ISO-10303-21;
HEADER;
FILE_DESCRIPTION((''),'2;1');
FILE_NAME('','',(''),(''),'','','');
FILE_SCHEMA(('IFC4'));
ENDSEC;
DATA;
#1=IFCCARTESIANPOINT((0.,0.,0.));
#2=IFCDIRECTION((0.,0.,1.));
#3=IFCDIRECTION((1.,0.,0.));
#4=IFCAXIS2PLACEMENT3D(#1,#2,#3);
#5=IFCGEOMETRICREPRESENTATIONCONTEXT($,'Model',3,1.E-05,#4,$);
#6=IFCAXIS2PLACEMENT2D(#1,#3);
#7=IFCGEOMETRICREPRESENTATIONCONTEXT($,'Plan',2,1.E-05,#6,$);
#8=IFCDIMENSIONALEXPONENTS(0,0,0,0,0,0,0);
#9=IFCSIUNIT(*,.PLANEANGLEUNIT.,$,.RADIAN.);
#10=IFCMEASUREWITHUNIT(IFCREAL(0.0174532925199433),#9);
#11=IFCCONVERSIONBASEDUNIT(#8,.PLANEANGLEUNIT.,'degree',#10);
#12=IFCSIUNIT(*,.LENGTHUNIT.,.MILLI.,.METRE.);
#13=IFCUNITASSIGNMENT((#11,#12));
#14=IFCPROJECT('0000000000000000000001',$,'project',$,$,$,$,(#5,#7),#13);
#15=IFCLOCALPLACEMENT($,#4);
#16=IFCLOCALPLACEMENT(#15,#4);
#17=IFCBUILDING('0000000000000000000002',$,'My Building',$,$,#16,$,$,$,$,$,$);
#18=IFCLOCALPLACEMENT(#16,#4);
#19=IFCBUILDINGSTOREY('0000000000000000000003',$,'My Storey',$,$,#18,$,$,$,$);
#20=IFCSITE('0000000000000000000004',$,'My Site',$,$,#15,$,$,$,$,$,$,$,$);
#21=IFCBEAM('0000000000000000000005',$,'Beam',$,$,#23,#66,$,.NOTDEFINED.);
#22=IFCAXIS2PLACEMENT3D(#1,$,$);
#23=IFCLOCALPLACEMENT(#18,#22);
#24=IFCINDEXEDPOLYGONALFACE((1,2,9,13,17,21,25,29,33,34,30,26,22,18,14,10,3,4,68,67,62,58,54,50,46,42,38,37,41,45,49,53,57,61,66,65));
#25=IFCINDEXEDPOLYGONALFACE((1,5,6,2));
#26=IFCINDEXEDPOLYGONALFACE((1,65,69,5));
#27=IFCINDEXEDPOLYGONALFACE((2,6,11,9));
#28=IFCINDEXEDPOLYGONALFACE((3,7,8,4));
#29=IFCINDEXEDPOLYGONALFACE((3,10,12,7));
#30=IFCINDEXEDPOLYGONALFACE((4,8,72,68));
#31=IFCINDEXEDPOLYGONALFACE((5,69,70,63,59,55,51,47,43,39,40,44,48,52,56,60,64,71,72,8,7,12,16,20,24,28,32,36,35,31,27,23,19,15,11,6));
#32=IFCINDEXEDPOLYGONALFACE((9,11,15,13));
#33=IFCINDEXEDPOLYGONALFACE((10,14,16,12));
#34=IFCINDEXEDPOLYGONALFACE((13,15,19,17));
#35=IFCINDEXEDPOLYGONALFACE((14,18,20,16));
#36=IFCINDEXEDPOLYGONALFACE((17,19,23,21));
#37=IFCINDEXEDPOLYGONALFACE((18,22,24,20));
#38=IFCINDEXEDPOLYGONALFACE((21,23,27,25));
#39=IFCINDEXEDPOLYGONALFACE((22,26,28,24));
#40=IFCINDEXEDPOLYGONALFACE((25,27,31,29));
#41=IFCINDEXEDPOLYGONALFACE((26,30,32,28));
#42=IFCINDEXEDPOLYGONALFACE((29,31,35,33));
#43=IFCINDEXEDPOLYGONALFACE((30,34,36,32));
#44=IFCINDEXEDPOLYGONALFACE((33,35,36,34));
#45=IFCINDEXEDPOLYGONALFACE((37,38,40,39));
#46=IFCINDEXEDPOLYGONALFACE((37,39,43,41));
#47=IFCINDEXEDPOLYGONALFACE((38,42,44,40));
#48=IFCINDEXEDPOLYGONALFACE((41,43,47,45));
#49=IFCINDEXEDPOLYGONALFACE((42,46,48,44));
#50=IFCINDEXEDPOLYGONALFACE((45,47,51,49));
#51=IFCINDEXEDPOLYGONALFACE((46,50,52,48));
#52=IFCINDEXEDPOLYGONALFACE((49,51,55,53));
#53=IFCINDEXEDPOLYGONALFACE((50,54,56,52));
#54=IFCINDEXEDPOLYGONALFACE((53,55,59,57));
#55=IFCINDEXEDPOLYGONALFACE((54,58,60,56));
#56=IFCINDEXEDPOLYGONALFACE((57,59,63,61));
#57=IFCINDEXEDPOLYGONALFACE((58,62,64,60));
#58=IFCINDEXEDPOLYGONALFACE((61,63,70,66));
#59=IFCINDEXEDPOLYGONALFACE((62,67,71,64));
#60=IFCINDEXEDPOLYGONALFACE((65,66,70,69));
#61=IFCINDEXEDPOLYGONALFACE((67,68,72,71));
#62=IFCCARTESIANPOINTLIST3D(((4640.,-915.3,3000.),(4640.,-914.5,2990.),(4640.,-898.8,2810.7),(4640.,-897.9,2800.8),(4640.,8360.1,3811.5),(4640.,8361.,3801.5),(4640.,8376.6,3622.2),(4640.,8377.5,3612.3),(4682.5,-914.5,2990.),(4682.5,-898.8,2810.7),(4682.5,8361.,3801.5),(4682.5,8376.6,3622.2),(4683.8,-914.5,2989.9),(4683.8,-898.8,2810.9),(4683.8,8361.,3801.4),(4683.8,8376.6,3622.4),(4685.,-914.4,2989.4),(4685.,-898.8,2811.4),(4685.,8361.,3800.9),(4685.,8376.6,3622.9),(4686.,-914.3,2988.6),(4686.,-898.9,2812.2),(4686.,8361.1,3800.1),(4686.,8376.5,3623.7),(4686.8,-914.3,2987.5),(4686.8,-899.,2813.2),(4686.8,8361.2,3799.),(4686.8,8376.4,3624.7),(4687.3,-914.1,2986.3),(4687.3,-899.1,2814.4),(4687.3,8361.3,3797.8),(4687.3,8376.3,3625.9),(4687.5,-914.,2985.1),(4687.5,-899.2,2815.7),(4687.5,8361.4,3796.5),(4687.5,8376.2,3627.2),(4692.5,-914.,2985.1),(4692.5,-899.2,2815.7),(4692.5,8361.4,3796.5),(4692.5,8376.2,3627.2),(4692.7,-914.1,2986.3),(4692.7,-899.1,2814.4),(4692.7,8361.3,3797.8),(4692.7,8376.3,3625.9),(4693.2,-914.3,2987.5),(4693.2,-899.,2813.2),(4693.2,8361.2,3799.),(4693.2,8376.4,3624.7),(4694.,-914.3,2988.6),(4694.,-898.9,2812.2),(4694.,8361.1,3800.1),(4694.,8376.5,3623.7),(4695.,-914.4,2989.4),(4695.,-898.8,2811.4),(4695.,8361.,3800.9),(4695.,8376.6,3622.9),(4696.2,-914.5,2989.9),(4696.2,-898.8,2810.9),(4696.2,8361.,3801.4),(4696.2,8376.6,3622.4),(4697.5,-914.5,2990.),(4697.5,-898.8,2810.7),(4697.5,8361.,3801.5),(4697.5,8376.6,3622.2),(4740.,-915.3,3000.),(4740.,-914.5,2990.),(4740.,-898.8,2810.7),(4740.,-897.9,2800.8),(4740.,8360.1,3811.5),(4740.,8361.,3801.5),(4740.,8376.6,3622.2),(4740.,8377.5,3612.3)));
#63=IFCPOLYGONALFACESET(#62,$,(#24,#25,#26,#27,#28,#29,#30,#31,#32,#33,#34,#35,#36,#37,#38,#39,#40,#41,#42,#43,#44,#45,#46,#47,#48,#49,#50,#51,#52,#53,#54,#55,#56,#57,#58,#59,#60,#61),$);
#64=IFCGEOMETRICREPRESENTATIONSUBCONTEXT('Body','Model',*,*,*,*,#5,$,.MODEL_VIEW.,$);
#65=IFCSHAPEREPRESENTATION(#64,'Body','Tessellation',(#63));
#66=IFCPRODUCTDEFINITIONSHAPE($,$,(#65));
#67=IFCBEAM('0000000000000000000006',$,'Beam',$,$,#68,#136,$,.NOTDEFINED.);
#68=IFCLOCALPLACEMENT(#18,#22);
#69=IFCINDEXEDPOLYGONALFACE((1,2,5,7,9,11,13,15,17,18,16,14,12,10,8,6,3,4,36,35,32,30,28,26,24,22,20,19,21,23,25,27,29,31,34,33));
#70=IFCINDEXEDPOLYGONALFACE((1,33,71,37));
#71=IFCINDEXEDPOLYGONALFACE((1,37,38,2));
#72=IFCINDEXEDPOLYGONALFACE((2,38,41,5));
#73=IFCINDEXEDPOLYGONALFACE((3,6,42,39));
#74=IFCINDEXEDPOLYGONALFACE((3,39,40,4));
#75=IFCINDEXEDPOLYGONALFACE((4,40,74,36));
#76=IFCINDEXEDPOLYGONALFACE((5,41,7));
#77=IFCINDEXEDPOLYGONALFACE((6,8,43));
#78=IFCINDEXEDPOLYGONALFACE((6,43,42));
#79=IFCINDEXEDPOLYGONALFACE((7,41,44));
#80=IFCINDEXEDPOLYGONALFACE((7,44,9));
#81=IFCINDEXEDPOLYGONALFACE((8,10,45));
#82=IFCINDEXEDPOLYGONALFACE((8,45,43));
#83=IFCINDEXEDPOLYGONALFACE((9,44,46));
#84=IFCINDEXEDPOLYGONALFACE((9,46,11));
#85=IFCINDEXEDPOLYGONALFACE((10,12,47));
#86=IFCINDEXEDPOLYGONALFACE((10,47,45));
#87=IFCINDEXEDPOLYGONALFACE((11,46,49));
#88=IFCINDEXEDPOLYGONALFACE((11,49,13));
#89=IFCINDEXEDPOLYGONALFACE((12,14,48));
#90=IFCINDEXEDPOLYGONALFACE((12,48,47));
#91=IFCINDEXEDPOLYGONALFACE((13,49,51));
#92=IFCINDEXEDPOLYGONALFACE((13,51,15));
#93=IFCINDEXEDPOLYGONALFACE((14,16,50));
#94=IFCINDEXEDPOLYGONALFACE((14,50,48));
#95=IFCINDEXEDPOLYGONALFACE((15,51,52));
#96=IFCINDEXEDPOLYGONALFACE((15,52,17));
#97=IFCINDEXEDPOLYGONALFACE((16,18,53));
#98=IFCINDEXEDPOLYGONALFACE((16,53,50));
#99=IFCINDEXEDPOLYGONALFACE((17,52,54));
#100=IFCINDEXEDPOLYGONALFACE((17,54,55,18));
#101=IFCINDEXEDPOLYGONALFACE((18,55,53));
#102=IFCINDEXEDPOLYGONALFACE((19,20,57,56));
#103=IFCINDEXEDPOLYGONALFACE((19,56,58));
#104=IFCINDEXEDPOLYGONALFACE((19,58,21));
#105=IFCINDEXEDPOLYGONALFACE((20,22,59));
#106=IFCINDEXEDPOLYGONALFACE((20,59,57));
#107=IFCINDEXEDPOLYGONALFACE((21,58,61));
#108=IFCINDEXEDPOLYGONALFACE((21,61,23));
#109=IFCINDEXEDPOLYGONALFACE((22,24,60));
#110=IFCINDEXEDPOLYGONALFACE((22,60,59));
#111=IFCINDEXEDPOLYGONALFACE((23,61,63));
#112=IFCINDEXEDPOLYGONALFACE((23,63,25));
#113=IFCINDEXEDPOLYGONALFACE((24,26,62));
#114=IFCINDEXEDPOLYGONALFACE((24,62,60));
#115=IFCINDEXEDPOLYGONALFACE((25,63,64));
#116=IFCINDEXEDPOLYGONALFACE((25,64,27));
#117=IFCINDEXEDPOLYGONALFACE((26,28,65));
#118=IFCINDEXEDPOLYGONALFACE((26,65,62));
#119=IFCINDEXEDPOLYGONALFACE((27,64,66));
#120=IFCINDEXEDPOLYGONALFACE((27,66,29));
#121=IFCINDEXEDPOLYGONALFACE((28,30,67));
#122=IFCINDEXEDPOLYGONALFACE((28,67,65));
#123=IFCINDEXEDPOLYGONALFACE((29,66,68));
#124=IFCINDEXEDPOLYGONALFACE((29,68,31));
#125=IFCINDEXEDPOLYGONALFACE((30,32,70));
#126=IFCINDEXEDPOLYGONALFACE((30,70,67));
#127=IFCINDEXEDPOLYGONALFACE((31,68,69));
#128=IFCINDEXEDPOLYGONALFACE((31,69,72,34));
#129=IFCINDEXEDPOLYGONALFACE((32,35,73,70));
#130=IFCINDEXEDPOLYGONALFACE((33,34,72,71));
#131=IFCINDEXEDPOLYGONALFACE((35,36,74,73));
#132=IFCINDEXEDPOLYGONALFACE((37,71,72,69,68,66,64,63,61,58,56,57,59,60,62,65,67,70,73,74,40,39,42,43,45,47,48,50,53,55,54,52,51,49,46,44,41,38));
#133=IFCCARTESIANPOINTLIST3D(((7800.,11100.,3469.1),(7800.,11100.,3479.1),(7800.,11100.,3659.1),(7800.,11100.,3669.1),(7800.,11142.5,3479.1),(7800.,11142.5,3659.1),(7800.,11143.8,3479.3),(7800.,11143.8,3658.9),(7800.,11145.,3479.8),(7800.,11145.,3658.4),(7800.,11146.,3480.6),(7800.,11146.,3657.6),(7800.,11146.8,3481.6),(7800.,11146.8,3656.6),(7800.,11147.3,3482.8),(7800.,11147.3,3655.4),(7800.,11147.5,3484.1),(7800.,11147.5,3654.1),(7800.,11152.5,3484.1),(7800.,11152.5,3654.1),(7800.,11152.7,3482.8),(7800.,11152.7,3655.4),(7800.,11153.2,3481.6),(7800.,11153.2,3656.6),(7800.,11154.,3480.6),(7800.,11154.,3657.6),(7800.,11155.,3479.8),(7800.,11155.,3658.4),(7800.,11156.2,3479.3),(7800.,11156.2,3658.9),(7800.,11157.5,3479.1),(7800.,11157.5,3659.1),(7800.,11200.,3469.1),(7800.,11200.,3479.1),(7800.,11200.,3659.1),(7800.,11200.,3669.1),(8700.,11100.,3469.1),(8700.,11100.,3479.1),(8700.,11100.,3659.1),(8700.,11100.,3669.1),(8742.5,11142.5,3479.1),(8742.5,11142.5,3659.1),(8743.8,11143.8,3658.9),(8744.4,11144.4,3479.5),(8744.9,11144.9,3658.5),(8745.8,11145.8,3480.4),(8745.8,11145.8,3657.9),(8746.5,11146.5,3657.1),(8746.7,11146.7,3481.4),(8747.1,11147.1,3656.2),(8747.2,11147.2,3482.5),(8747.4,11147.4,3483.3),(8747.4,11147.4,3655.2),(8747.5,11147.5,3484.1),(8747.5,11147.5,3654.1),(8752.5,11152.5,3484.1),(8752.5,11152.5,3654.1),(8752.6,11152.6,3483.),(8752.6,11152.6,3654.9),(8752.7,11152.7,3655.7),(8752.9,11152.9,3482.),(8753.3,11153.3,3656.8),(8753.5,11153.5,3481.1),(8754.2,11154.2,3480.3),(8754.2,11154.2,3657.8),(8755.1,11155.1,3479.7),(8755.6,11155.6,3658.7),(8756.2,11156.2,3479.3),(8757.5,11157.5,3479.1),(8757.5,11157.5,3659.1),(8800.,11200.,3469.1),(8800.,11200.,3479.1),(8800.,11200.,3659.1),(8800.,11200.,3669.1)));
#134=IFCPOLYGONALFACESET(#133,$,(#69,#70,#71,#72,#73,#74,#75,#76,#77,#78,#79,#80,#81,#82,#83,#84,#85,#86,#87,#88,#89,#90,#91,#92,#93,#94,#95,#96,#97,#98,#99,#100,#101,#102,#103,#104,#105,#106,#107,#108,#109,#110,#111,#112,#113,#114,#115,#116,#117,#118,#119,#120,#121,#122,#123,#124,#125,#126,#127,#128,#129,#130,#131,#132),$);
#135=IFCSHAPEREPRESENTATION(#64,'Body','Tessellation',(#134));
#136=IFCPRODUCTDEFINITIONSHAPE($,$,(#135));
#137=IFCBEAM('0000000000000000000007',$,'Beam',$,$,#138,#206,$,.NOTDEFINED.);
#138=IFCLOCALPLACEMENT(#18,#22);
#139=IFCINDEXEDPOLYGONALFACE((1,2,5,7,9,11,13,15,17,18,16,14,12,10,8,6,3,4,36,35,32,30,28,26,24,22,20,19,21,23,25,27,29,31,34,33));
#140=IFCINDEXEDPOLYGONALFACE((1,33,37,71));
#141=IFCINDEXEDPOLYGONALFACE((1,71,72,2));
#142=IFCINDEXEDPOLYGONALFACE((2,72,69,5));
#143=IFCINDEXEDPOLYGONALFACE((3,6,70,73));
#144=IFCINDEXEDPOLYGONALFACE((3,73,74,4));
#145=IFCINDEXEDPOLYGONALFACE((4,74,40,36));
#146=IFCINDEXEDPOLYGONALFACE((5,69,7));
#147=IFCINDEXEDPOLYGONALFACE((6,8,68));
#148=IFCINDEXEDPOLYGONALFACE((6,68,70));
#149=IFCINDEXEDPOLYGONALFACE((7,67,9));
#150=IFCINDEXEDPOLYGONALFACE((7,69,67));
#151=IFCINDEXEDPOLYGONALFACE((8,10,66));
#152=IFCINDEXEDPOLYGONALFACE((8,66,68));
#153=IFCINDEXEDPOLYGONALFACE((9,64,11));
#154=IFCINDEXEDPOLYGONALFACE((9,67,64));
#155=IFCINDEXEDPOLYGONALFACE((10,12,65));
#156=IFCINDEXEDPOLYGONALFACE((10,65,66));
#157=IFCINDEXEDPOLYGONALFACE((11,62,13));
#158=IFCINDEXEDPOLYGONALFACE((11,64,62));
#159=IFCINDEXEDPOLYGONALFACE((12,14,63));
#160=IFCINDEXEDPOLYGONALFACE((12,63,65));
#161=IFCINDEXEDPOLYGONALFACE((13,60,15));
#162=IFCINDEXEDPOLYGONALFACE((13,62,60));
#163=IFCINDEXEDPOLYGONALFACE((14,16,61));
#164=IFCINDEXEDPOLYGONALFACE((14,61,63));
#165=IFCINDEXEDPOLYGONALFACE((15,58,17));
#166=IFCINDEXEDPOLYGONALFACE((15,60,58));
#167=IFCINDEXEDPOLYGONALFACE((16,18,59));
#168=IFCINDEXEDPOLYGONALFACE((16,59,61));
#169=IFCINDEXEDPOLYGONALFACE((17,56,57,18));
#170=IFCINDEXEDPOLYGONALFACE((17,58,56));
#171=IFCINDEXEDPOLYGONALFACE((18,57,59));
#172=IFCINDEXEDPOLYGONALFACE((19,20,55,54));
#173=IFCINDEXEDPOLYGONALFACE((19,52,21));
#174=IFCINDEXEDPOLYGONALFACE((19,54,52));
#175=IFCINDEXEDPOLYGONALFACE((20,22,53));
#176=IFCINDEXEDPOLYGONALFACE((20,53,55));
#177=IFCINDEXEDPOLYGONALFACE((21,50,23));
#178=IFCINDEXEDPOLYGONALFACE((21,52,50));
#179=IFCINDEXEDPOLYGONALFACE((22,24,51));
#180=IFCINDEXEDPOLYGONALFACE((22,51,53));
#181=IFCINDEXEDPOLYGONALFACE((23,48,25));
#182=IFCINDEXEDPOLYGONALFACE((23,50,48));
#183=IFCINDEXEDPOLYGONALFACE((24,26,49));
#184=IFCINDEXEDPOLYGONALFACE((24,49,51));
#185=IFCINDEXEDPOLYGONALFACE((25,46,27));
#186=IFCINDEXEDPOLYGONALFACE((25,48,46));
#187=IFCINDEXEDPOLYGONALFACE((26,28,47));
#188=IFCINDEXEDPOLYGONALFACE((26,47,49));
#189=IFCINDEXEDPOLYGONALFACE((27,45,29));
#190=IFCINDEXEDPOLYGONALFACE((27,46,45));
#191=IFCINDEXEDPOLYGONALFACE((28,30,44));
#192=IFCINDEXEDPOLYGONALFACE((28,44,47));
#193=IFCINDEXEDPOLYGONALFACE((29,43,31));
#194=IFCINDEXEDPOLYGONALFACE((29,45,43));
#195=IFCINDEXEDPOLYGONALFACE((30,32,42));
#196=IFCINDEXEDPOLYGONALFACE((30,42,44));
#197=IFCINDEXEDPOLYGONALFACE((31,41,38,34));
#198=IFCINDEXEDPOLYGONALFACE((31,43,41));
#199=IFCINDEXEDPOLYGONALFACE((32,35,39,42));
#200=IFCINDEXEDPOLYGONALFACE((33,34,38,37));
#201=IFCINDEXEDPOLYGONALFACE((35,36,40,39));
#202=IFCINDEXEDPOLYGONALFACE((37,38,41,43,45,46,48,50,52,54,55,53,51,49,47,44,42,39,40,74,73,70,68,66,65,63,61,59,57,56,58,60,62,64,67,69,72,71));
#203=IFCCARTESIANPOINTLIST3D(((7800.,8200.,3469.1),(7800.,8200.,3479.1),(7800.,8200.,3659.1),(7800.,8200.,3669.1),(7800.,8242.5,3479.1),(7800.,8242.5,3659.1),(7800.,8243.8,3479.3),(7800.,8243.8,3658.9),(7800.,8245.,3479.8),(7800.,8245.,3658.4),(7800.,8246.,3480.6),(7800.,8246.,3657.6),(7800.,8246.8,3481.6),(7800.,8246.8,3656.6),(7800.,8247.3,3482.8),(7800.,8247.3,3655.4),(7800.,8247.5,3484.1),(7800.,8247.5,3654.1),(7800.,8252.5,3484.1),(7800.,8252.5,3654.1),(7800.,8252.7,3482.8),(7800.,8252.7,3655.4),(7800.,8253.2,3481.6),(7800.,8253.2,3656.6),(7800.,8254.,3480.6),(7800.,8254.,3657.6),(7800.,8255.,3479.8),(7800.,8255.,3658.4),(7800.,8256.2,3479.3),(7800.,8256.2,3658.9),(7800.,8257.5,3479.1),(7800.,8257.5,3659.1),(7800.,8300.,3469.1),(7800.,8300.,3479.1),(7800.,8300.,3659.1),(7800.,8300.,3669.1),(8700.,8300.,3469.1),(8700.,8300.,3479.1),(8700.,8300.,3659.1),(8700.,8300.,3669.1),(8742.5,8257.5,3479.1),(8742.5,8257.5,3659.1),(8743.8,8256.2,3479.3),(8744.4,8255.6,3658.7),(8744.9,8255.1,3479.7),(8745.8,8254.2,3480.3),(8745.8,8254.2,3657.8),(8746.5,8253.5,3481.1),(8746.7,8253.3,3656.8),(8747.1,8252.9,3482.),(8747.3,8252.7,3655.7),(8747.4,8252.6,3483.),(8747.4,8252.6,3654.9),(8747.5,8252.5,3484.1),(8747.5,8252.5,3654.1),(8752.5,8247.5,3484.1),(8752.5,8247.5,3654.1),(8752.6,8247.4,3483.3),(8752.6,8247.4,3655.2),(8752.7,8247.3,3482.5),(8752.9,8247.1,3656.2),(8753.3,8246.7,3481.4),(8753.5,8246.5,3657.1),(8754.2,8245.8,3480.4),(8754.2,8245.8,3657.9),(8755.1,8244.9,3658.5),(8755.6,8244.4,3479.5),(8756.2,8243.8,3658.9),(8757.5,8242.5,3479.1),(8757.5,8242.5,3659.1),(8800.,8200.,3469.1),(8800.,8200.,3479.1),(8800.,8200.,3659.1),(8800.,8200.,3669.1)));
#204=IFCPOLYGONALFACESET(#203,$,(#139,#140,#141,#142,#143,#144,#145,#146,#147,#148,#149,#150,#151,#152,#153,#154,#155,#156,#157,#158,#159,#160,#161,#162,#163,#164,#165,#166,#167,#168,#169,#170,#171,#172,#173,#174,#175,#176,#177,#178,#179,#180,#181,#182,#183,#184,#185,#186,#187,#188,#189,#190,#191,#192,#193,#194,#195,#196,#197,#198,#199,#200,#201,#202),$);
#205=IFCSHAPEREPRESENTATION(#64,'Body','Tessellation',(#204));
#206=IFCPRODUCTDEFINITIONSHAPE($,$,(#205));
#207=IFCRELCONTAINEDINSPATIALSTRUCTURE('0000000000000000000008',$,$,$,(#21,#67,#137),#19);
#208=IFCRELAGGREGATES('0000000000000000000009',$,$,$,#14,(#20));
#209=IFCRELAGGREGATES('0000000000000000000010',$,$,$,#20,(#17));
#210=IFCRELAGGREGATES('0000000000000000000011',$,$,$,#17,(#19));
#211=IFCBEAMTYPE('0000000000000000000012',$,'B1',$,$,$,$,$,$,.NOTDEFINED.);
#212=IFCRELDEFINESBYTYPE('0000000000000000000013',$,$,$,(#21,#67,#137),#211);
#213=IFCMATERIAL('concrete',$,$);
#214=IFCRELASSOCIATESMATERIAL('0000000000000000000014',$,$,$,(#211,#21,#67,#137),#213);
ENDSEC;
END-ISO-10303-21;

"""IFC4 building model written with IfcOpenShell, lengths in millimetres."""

from ifc_helpers import new_model, entity, si_unit, converted_unit, frame, frame_2d, origin_with_axes, place, context, subcontext, project, spatial, i_section, extrude, clip, halfspace, material, material_profile, profile_set, profile_usage, type_object, element, save


model = new_model("IFC4")

# Units and contexts
model_context = context("Model", 3, precision=1e-05, world=origin_with_axes())
plan_context = context("Plan", 2, precision=1e-05, world=frame_2d((0.0, 0.0, 0.0), x_axis=(1.0, 0.0, 0.0)))
body_context = subcontext(model_context, "Body", "Model", "MODEL_VIEW")
ifc_project = project(units=[converted_unit("PLANEANGLEUNIT", "degree", entity("IfcReal", 0.0174532925199433), si_unit("PLANEANGLEUNIT", "RADIAN"), dimensions=[0, 0, 0, 0, 0, 0, 0]), si_unit("LENGTHUNIT", "METRE", prefix="MILLI")], contexts=[model_context, plan_context])

# Site, building, storey
site_placement = place(None, origin_with_axes())
site = spatial("IfcSite", under=ifc_project, at=site_placement, Name="My Site")
building_placement = place(site_placement, origin_with_axes())
building = spatial("IfcBuilding", under=site, at=building_placement, Name="My Building")
storey_placement = place(building_placement, origin_with_axes())
storey = spatial("IfcBuildingStorey", under=building, at=storey_placement, Name="My Storey")

# Beams
ifc_material = material(Name="concrete")
ifc_material_profile = material_profile(ifc_material, i_section(OverallWidth=100.0, OverallDepth=200.0, WebThickness=5.0, FlangeThickness=10.0, FilletRadius=5.0))
ifc_profile_set = profile_set([ifc_material_profile])
beam_type = type_object("IfcBeamType", Name="B1", PredefinedType="NOTDEFINED", material=ifc_profile_set)
ifc_profile_usage_1 = profile_usage(ifc_profile_set, cardinal=5)
beam_1_placement = place(storey_placement, frame((4690.0, -906.6, 2900.4), z_axis=(-0.000001, 0.996195, 0.087156), x_axis=(-1.0, -0.000001, 0.0)))
element("IfcBeam", 1, at=beam_1_placement, inside=storey, type_object=beam_type, material=ifc_profile_usage_1, Name="Beam", PredefinedType="NOTDEFINED", context=body_context, shape_type="SweptSolid", body=[
    extrude(i_section(OverallWidth=100.0, OverallDepth=200.0, WebThickness=5.0, FlangeThickness=10.0, FilletRadius=5.0), origin_with_axes(), (0.0, 0.0, 1.0), 9310.9),
])
ifc_profile_usage_2 = profile_usage(ifc_profile_set, cardinal=5)
beam_2_placement = place(storey_placement, frame((7800.0, 11150.0, 3569.1), z_axis=(1.0, 0.0, 0.0), x_axis=(0.0, 1.0, 0.0)))
element("IfcBeam", 2, at=beam_2_placement, inside=storey, type_object=beam_type, material=ifc_profile_usage_2, Name="Beam", PredefinedType="NOTDEFINED", context=body_context, shape_type="Clipping", body=[
    clip(extrude(i_section(OverallWidth=100.0, OverallDepth=200.0, WebThickness=5.0, FlangeThickness=10.0, FilletRadius=5.0), origin_with_axes(), (0.0, 0.0, 1.0), 1000.0), halfspace(frame((50.0, -3569.1, 1000.0), z_axis=(-0.707107, 0.0, 0.707107), x_axis=(-0.707107, 0.0, -0.707107)), False)),
])
ifc_profile_usage_3 = profile_usage(ifc_profile_set, cardinal=5)
beam_3_placement = place(storey_placement, frame((7800.0, 8250.0, 3569.1), z_axis=(1.0, 0.0, 0.0), x_axis=(0.0, 1.0, 0.0)))
element("IfcBeam", 3, at=beam_3_placement, inside=storey, type_object=beam_type, material=ifc_profile_usage_3, Name="Beam", PredefinedType="NOTDEFINED", context=body_context, shape_type="Clipping", body=[
    clip(extrude(i_section(OverallWidth=100.0, OverallDepth=200.0, WebThickness=5.0, FlangeThickness=10.0, FilletRadius=5.0), origin_with_axes(), (0.0, 0.0, 1.0), 1000.0), halfspace(frame((-50.0, -3569.1, 1000.0), z_axis=(0.707107, 0.0, 0.707107), x_axis=(0.707107, 0.0, -0.707107)), False)),
])

save(model, "model.ifc")
